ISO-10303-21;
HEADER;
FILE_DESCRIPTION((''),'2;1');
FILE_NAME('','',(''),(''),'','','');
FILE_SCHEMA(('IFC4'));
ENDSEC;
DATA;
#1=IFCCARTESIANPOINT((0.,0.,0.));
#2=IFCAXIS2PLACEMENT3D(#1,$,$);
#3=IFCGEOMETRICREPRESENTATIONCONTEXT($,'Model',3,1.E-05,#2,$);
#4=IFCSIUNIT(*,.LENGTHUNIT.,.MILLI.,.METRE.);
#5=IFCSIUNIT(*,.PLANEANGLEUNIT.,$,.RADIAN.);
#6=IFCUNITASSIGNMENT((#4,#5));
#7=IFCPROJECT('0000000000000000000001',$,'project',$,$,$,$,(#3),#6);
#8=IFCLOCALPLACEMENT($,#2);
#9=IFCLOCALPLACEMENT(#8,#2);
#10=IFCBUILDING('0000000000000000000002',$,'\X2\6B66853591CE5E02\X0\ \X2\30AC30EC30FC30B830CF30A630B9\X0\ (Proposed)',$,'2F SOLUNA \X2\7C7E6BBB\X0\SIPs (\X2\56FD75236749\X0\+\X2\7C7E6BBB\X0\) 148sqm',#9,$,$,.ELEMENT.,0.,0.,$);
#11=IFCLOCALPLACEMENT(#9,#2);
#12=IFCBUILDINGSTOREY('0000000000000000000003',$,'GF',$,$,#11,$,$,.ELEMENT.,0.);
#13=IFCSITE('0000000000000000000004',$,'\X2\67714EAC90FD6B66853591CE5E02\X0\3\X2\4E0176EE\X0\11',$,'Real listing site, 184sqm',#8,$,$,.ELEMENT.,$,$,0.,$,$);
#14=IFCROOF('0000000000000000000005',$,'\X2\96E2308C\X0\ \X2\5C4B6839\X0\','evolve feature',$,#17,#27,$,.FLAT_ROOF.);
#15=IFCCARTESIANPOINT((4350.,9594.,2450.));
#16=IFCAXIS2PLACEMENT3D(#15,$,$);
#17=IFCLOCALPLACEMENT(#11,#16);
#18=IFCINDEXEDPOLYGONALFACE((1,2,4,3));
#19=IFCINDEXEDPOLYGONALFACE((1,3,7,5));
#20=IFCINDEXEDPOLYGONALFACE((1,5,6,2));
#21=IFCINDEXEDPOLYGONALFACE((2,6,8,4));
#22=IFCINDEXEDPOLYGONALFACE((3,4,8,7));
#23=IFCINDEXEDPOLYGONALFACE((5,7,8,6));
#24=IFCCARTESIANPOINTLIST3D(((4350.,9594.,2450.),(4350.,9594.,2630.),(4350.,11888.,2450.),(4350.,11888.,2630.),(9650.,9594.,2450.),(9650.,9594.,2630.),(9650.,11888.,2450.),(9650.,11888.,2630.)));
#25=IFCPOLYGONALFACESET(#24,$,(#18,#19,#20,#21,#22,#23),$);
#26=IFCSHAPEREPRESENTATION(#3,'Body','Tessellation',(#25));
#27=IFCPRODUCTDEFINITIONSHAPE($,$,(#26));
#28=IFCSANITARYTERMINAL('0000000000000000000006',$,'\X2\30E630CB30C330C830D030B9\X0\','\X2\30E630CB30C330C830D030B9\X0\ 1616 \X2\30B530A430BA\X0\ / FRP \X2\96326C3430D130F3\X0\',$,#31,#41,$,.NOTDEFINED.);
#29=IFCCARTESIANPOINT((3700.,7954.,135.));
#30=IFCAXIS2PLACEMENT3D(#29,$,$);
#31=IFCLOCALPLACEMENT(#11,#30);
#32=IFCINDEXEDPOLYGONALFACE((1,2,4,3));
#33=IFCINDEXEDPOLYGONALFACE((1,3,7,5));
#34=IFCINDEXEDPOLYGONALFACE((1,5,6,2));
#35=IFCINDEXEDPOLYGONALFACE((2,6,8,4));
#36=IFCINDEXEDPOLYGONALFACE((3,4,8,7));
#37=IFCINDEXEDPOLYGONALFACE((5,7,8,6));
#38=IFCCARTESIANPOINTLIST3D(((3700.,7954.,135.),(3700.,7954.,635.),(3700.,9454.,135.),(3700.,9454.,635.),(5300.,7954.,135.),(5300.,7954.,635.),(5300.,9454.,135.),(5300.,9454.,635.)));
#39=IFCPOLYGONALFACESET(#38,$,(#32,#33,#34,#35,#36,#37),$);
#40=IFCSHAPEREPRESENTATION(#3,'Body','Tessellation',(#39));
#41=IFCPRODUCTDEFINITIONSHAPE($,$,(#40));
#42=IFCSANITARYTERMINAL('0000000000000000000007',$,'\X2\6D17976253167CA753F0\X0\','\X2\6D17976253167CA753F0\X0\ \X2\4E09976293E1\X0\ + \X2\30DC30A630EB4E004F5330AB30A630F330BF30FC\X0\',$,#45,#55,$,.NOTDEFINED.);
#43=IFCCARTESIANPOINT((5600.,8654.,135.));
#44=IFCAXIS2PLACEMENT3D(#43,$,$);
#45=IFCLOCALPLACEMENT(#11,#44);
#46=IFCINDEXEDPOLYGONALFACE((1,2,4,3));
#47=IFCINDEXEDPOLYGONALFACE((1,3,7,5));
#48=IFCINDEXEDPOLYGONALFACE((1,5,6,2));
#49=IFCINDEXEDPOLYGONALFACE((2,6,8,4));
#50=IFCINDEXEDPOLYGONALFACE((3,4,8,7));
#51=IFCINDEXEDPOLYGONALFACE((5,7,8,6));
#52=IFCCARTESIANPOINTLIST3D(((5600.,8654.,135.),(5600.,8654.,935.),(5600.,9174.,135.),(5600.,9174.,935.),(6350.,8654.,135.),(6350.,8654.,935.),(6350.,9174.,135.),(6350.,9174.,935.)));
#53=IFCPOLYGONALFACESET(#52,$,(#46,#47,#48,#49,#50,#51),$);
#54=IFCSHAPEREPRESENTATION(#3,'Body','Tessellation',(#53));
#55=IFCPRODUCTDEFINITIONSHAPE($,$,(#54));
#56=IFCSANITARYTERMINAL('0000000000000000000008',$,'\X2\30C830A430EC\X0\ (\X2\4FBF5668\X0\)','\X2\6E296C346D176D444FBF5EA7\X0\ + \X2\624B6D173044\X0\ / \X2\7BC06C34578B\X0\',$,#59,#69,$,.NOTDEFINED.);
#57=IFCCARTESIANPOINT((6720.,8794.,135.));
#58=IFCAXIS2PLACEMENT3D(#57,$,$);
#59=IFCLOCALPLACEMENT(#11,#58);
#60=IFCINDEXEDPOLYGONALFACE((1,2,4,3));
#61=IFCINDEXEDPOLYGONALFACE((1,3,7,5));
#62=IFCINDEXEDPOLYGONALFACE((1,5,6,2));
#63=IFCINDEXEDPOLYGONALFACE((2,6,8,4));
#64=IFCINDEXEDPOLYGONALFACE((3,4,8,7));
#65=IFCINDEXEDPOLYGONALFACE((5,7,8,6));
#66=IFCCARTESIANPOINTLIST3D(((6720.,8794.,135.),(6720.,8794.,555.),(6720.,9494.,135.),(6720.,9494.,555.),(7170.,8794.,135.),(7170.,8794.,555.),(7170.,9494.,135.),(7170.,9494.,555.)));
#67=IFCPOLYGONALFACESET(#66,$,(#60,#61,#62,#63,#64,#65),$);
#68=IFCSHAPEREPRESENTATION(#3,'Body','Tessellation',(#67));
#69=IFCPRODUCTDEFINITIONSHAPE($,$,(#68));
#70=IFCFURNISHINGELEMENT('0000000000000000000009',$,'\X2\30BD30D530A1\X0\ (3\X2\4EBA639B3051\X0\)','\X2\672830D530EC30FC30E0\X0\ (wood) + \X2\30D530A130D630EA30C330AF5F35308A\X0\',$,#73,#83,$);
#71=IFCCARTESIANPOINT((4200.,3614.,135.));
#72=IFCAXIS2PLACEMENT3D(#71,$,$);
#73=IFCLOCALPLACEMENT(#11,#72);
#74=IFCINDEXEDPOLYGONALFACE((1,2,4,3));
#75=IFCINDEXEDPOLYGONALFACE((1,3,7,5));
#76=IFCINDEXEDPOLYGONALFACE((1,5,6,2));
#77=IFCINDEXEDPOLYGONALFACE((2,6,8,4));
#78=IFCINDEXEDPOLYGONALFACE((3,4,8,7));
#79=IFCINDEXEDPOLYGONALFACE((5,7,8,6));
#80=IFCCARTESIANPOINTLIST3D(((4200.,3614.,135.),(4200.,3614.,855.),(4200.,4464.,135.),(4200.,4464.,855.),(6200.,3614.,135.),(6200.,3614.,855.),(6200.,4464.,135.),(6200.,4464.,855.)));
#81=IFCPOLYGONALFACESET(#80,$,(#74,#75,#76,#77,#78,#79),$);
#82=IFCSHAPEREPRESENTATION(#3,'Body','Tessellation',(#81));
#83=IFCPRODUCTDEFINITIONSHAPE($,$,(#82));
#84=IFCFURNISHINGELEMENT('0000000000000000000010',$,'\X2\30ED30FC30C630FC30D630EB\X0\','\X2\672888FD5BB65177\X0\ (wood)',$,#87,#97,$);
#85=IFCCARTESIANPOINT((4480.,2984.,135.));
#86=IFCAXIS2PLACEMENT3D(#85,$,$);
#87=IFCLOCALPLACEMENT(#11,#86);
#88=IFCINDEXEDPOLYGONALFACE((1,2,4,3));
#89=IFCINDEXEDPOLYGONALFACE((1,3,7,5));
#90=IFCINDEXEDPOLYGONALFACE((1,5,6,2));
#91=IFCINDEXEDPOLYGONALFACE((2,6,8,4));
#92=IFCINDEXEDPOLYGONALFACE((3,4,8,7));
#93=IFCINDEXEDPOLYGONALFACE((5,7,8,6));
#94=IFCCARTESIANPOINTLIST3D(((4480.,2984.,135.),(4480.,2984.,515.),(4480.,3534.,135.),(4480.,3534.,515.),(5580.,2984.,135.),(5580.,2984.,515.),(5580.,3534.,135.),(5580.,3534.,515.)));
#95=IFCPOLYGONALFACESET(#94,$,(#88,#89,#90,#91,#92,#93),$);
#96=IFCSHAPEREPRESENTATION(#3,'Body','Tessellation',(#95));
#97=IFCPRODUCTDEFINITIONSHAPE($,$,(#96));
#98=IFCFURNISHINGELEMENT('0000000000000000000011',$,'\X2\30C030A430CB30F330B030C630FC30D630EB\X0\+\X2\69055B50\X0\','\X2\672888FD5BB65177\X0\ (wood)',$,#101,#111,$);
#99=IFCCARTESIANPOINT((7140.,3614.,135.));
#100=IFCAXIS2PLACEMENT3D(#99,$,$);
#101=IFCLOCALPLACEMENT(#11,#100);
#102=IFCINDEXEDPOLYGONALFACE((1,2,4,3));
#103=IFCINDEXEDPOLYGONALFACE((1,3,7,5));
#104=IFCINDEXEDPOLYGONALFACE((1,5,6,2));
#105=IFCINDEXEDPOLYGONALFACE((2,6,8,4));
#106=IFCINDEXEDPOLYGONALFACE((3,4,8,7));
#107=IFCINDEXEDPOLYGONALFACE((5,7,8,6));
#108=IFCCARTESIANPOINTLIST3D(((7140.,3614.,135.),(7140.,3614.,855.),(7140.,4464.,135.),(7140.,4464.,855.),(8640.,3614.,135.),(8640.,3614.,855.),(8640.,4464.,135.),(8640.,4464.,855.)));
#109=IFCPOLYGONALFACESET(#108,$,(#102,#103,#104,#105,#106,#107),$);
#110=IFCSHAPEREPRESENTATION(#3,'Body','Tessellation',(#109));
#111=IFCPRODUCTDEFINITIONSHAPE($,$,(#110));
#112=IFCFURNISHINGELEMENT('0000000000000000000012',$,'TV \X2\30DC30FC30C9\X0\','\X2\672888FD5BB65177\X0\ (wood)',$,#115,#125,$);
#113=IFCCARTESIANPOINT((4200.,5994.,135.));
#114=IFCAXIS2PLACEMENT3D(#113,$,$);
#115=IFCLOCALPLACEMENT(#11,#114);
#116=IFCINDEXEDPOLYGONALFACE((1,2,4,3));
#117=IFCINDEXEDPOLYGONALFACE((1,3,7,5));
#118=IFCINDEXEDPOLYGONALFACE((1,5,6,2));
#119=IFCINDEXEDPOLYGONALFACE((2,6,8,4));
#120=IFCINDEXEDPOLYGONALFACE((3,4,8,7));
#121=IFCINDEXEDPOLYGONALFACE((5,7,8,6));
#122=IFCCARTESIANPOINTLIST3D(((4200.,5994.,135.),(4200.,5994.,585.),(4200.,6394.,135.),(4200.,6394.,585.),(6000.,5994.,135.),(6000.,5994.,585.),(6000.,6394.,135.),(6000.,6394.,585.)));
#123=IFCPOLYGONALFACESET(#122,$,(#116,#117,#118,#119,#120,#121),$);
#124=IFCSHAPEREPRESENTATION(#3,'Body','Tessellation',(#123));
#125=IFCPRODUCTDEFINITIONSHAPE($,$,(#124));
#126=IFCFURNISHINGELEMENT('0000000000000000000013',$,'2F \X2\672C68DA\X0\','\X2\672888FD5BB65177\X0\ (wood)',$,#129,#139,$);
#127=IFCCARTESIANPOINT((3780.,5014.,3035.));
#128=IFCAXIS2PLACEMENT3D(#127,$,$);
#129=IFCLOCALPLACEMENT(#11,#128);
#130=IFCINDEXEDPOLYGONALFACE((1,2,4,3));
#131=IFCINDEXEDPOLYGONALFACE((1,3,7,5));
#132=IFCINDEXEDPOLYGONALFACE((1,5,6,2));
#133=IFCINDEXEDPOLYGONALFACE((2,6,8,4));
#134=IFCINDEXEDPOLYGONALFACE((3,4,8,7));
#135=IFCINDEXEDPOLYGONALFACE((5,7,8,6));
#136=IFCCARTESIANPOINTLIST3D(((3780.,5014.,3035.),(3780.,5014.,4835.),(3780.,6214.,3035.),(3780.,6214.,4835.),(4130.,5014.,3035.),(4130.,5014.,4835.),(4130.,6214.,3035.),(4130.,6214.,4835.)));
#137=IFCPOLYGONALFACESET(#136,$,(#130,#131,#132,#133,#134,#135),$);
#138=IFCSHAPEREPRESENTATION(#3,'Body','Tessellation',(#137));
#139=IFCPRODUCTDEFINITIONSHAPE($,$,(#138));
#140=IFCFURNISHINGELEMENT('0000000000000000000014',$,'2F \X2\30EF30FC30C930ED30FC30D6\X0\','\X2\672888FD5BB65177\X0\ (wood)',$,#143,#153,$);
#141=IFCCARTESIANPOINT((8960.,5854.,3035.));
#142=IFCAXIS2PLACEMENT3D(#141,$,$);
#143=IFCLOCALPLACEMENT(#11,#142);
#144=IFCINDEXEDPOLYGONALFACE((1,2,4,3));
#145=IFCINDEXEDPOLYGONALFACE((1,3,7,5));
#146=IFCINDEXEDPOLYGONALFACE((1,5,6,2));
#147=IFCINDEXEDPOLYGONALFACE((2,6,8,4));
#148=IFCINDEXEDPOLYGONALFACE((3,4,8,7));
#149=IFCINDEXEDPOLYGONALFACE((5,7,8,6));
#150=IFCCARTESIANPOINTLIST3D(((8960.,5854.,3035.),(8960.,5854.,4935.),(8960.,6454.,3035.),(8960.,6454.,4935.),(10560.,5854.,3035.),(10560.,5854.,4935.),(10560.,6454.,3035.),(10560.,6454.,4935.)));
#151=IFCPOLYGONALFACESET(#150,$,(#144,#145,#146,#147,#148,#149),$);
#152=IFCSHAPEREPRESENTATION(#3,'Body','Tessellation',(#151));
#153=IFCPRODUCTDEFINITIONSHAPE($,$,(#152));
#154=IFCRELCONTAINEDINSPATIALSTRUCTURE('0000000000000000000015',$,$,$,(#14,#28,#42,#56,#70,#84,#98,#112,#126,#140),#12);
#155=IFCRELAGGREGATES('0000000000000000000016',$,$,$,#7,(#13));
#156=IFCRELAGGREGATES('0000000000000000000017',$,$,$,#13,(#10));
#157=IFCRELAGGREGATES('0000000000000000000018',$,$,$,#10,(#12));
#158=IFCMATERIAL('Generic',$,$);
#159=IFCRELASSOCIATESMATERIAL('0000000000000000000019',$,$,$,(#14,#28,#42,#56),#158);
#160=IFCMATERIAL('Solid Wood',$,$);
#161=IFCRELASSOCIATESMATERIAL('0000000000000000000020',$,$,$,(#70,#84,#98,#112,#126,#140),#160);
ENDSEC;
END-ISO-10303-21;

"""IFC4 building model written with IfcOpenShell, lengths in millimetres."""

from ifc_helpers import new_model, si_unit, frame, frame_2d, origin, place, context, project, spatial, rectangle, extrude, material, element, save


model = new_model("IFC4")

# Units and contexts
model_context = context("Model", 3, precision=1e-05, world=origin())
ifc_project = project(units=[si_unit("LENGTHUNIT", "METRE", prefix="MILLI"), si_unit("PLANEANGLEUNIT", "RADIAN")], contexts=[model_context])

# Site, building, storey
site_placement = place(None, origin())
site = spatial("IfcSite", under=ifc_project, at=site_placement, Name="東京都武蔵野市3丁目11", ObjectType="Real listing site, 184sqm", CompositionType="ELEMENT", RefElevation=0.0)
building_placement = place(site_placement, origin())
building = spatial("IfcBuilding", under=site, at=building_placement, Name="武蔵野市 ガレージハウス (Proposed)", ObjectType="2F SOLUNA 籾殻SIPs (国産杉+籾殻) 148sqm", CompositionType="ELEMENT", ElevationOfRefHeight=0.0, ElevationOfTerrain=0.0)
storey_placement = place(building_placement, origin())
storey = spatial("IfcBuildingStorey", under=building, at=storey_placement, Name="GF", CompositionType="ELEMENT", Elevation=0.0)

# Shared definitions
ifc_material_1 = material(Name="Generic")

# Shared definitions
ifc_material_2 = material(Name="Solid Wood")

# Roof
roof_placement = place(storey_placement, frame((4350.0, 9594.0, 2450.0)))
element("IfcRoof", 1, at=roof_placement, inside=storey, material=ifc_material_1, Name="離れ 屋根", Description="evolve feature", PredefinedType="FLAT_ROOF", context=model_context, shape_type="SweptSolid", body=[
    extrude(rectangle(XDim=5300.0, YDim=2294.0, at=frame_2d((2650.0, 1147.0))), frame((4350.0, 9594.0, 2450.0)), (0.0, 0.0, 1.0), 180.0),
])

# Sanitary terminals
sanitary_terminal_1_placement = place(storey_placement, frame((3700.0, 7954.0, 135.0)))
element("IfcSanitaryTerminal", 2, at=sanitary_terminal_1_placement, inside=storey, material=ifc_material_1, Name="ユニットバス", Description="ユニットバス 1616 サイズ / FRP 防水パン", PredefinedType="NOTDEFINED", context=model_context, shape_type="SweptSolid", body=[
    extrude(rectangle(XDim=1600.0, YDim=1500.0, at=frame_2d((800.0, 750.0))), frame((3700.0, 7954.0, 135.0)), (0.0, 0.0, 1.0), 500.0),
])
sanitary_terminal_2_placement = place(storey_placement, frame((5600.0, 8654.0, 135.0)))
element("IfcSanitaryTerminal", 3, at=sanitary_terminal_2_placement, inside=storey, material=ifc_material_1, Name="洗面化粧台", Description="洗面化粧台 三面鏡 + ボウル一体カウンター", PredefinedType="NOTDEFINED", context=model_context, shape_type="SweptSolid", body=[
    extrude(rectangle(XDim=750.0, YDim=520.0, at=frame_2d((375.0, 260.0))), frame((5600.0, 8654.0, 135.0)), (0.0, 0.0, 1.0), 800.0),
])
sanitary_terminal_3_placement = place(storey_placement, frame((6720.0, 8794.0, 135.0)))
element("IfcSanitaryTerminal", 4, at=sanitary_terminal_3_placement, inside=storey, material=ifc_material_1, Name="トイレ (便器)", Description="温水洗浄便座 + 手洗い / 節水型", PredefinedType="NOTDEFINED", context=model_context, shape_type="SweptSolid", body=[
    extrude(rectangle(XDim=450.0, YDim=700.0, at=frame_2d((225.0, 350.0))), frame((6720.0, 8794.0, 135.0)), (0.0, 0.0, 1.0), 420.0),
])

# Furnishing elements
furnishing_1_placement = place(storey_placement, frame((4200.0, 3614.0, 135.0)))
element("IfcFurnishingElement", 5, at=furnishing_1_placement, inside=storey, material=ifc_material_2, Name="ソファ (3人掛け)", Description="木フレーム (wood) + ファブリック張り", context=model_context, shape_type="SweptSolid", body=[
    extrude(rectangle(XDim=2000.0, YDim=850.0, at=frame_2d((1000.0, 425.0))), frame((4200.0, 3614.0, 135.0)), (0.0, 0.0, 1.0), 720.0),
])
furnishing_2_placement = place(storey_placement, frame((4480.0, 2984.0, 135.0)))
element("IfcFurnishingElement", 6, at=furnishing_2_placement, inside=storey, material=ifc_material_2, Name="ローテーブル", Description="木製家具 (wood)", context=model_context, shape_type="SweptSolid", body=[
    extrude(rectangle(XDim=1100.0, YDim=550.0, at=frame_2d((550.0, 275.0))), frame((4480.0, 2984.0, 135.0)), (0.0, 0.0, 1.0), 380.0),
])
furnishing_3_placement = place(storey_placement, frame((7140.0, 3614.0, 135.0)))
element("IfcFurnishingElement", 7, at=furnishing_3_placement, inside=storey, material=ifc_material_2, Name="ダイニングテーブル+椅子", Description="木製家具 (wood)", context=model_context, shape_type="SweptSolid", body=[
    extrude(rectangle(XDim=1500.0, YDim=850.0, at=frame_2d((750.0, 425.0))), frame((7140.0, 3614.0, 135.0)), (0.0, 0.0, 1.0), 720.0),
])
furnishing_4_placement = place(storey_placement, frame((4200.0, 5994.0, 135.0)))
element("IfcFurnishingElement", 8, at=furnishing_4_placement, inside=storey, material=ifc_material_2, Name="TV ボード", Description="木製家具 (wood)", context=model_context, shape_type="SweptSolid", body=[
    extrude(rectangle(XDim=1800.0, YDim=400.0, at=frame_2d((900.0, 200.0))), frame((4200.0, 5994.0, 135.0)), (0.0, 0.0, 1.0), 450.0),
])
furnishing_5_placement = place(storey_placement, frame((3780.0, 5014.0, 3035.0)))
element("IfcFurnishingElement", 9, at=furnishing_5_placement, inside=storey, material=ifc_material_2, Name="2F 本棚", Description="木製家具 (wood)", context=model_context, shape_type="SweptSolid", body=[
    extrude(rectangle(XDim=350.0, YDim=1200.0, at=frame_2d((175.0, 600.0))), frame((3780.0, 5014.0, 3035.0)), (0.0, 0.0, 1.0), 1800.0),
])
furnishing_6_placement = place(storey_placement, frame((8960.0, 5854.0, 3035.0)))
element("IfcFurnishingElement", 10, at=furnishing_6_placement, inside=storey, material=ifc_material_2, Name="2F ワードローブ", Description="木製家具 (wood)", context=model_context, shape_type="SweptSolid", body=[
    extrude(rectangle(XDim=1600.0, YDim=600.0, at=frame_2d((800.0, 300.0))), frame((8960.0, 5854.0, 3035.0)), (0.0, 0.0, 1.0), 1900.0),
])

save(model, "model.ifc")
